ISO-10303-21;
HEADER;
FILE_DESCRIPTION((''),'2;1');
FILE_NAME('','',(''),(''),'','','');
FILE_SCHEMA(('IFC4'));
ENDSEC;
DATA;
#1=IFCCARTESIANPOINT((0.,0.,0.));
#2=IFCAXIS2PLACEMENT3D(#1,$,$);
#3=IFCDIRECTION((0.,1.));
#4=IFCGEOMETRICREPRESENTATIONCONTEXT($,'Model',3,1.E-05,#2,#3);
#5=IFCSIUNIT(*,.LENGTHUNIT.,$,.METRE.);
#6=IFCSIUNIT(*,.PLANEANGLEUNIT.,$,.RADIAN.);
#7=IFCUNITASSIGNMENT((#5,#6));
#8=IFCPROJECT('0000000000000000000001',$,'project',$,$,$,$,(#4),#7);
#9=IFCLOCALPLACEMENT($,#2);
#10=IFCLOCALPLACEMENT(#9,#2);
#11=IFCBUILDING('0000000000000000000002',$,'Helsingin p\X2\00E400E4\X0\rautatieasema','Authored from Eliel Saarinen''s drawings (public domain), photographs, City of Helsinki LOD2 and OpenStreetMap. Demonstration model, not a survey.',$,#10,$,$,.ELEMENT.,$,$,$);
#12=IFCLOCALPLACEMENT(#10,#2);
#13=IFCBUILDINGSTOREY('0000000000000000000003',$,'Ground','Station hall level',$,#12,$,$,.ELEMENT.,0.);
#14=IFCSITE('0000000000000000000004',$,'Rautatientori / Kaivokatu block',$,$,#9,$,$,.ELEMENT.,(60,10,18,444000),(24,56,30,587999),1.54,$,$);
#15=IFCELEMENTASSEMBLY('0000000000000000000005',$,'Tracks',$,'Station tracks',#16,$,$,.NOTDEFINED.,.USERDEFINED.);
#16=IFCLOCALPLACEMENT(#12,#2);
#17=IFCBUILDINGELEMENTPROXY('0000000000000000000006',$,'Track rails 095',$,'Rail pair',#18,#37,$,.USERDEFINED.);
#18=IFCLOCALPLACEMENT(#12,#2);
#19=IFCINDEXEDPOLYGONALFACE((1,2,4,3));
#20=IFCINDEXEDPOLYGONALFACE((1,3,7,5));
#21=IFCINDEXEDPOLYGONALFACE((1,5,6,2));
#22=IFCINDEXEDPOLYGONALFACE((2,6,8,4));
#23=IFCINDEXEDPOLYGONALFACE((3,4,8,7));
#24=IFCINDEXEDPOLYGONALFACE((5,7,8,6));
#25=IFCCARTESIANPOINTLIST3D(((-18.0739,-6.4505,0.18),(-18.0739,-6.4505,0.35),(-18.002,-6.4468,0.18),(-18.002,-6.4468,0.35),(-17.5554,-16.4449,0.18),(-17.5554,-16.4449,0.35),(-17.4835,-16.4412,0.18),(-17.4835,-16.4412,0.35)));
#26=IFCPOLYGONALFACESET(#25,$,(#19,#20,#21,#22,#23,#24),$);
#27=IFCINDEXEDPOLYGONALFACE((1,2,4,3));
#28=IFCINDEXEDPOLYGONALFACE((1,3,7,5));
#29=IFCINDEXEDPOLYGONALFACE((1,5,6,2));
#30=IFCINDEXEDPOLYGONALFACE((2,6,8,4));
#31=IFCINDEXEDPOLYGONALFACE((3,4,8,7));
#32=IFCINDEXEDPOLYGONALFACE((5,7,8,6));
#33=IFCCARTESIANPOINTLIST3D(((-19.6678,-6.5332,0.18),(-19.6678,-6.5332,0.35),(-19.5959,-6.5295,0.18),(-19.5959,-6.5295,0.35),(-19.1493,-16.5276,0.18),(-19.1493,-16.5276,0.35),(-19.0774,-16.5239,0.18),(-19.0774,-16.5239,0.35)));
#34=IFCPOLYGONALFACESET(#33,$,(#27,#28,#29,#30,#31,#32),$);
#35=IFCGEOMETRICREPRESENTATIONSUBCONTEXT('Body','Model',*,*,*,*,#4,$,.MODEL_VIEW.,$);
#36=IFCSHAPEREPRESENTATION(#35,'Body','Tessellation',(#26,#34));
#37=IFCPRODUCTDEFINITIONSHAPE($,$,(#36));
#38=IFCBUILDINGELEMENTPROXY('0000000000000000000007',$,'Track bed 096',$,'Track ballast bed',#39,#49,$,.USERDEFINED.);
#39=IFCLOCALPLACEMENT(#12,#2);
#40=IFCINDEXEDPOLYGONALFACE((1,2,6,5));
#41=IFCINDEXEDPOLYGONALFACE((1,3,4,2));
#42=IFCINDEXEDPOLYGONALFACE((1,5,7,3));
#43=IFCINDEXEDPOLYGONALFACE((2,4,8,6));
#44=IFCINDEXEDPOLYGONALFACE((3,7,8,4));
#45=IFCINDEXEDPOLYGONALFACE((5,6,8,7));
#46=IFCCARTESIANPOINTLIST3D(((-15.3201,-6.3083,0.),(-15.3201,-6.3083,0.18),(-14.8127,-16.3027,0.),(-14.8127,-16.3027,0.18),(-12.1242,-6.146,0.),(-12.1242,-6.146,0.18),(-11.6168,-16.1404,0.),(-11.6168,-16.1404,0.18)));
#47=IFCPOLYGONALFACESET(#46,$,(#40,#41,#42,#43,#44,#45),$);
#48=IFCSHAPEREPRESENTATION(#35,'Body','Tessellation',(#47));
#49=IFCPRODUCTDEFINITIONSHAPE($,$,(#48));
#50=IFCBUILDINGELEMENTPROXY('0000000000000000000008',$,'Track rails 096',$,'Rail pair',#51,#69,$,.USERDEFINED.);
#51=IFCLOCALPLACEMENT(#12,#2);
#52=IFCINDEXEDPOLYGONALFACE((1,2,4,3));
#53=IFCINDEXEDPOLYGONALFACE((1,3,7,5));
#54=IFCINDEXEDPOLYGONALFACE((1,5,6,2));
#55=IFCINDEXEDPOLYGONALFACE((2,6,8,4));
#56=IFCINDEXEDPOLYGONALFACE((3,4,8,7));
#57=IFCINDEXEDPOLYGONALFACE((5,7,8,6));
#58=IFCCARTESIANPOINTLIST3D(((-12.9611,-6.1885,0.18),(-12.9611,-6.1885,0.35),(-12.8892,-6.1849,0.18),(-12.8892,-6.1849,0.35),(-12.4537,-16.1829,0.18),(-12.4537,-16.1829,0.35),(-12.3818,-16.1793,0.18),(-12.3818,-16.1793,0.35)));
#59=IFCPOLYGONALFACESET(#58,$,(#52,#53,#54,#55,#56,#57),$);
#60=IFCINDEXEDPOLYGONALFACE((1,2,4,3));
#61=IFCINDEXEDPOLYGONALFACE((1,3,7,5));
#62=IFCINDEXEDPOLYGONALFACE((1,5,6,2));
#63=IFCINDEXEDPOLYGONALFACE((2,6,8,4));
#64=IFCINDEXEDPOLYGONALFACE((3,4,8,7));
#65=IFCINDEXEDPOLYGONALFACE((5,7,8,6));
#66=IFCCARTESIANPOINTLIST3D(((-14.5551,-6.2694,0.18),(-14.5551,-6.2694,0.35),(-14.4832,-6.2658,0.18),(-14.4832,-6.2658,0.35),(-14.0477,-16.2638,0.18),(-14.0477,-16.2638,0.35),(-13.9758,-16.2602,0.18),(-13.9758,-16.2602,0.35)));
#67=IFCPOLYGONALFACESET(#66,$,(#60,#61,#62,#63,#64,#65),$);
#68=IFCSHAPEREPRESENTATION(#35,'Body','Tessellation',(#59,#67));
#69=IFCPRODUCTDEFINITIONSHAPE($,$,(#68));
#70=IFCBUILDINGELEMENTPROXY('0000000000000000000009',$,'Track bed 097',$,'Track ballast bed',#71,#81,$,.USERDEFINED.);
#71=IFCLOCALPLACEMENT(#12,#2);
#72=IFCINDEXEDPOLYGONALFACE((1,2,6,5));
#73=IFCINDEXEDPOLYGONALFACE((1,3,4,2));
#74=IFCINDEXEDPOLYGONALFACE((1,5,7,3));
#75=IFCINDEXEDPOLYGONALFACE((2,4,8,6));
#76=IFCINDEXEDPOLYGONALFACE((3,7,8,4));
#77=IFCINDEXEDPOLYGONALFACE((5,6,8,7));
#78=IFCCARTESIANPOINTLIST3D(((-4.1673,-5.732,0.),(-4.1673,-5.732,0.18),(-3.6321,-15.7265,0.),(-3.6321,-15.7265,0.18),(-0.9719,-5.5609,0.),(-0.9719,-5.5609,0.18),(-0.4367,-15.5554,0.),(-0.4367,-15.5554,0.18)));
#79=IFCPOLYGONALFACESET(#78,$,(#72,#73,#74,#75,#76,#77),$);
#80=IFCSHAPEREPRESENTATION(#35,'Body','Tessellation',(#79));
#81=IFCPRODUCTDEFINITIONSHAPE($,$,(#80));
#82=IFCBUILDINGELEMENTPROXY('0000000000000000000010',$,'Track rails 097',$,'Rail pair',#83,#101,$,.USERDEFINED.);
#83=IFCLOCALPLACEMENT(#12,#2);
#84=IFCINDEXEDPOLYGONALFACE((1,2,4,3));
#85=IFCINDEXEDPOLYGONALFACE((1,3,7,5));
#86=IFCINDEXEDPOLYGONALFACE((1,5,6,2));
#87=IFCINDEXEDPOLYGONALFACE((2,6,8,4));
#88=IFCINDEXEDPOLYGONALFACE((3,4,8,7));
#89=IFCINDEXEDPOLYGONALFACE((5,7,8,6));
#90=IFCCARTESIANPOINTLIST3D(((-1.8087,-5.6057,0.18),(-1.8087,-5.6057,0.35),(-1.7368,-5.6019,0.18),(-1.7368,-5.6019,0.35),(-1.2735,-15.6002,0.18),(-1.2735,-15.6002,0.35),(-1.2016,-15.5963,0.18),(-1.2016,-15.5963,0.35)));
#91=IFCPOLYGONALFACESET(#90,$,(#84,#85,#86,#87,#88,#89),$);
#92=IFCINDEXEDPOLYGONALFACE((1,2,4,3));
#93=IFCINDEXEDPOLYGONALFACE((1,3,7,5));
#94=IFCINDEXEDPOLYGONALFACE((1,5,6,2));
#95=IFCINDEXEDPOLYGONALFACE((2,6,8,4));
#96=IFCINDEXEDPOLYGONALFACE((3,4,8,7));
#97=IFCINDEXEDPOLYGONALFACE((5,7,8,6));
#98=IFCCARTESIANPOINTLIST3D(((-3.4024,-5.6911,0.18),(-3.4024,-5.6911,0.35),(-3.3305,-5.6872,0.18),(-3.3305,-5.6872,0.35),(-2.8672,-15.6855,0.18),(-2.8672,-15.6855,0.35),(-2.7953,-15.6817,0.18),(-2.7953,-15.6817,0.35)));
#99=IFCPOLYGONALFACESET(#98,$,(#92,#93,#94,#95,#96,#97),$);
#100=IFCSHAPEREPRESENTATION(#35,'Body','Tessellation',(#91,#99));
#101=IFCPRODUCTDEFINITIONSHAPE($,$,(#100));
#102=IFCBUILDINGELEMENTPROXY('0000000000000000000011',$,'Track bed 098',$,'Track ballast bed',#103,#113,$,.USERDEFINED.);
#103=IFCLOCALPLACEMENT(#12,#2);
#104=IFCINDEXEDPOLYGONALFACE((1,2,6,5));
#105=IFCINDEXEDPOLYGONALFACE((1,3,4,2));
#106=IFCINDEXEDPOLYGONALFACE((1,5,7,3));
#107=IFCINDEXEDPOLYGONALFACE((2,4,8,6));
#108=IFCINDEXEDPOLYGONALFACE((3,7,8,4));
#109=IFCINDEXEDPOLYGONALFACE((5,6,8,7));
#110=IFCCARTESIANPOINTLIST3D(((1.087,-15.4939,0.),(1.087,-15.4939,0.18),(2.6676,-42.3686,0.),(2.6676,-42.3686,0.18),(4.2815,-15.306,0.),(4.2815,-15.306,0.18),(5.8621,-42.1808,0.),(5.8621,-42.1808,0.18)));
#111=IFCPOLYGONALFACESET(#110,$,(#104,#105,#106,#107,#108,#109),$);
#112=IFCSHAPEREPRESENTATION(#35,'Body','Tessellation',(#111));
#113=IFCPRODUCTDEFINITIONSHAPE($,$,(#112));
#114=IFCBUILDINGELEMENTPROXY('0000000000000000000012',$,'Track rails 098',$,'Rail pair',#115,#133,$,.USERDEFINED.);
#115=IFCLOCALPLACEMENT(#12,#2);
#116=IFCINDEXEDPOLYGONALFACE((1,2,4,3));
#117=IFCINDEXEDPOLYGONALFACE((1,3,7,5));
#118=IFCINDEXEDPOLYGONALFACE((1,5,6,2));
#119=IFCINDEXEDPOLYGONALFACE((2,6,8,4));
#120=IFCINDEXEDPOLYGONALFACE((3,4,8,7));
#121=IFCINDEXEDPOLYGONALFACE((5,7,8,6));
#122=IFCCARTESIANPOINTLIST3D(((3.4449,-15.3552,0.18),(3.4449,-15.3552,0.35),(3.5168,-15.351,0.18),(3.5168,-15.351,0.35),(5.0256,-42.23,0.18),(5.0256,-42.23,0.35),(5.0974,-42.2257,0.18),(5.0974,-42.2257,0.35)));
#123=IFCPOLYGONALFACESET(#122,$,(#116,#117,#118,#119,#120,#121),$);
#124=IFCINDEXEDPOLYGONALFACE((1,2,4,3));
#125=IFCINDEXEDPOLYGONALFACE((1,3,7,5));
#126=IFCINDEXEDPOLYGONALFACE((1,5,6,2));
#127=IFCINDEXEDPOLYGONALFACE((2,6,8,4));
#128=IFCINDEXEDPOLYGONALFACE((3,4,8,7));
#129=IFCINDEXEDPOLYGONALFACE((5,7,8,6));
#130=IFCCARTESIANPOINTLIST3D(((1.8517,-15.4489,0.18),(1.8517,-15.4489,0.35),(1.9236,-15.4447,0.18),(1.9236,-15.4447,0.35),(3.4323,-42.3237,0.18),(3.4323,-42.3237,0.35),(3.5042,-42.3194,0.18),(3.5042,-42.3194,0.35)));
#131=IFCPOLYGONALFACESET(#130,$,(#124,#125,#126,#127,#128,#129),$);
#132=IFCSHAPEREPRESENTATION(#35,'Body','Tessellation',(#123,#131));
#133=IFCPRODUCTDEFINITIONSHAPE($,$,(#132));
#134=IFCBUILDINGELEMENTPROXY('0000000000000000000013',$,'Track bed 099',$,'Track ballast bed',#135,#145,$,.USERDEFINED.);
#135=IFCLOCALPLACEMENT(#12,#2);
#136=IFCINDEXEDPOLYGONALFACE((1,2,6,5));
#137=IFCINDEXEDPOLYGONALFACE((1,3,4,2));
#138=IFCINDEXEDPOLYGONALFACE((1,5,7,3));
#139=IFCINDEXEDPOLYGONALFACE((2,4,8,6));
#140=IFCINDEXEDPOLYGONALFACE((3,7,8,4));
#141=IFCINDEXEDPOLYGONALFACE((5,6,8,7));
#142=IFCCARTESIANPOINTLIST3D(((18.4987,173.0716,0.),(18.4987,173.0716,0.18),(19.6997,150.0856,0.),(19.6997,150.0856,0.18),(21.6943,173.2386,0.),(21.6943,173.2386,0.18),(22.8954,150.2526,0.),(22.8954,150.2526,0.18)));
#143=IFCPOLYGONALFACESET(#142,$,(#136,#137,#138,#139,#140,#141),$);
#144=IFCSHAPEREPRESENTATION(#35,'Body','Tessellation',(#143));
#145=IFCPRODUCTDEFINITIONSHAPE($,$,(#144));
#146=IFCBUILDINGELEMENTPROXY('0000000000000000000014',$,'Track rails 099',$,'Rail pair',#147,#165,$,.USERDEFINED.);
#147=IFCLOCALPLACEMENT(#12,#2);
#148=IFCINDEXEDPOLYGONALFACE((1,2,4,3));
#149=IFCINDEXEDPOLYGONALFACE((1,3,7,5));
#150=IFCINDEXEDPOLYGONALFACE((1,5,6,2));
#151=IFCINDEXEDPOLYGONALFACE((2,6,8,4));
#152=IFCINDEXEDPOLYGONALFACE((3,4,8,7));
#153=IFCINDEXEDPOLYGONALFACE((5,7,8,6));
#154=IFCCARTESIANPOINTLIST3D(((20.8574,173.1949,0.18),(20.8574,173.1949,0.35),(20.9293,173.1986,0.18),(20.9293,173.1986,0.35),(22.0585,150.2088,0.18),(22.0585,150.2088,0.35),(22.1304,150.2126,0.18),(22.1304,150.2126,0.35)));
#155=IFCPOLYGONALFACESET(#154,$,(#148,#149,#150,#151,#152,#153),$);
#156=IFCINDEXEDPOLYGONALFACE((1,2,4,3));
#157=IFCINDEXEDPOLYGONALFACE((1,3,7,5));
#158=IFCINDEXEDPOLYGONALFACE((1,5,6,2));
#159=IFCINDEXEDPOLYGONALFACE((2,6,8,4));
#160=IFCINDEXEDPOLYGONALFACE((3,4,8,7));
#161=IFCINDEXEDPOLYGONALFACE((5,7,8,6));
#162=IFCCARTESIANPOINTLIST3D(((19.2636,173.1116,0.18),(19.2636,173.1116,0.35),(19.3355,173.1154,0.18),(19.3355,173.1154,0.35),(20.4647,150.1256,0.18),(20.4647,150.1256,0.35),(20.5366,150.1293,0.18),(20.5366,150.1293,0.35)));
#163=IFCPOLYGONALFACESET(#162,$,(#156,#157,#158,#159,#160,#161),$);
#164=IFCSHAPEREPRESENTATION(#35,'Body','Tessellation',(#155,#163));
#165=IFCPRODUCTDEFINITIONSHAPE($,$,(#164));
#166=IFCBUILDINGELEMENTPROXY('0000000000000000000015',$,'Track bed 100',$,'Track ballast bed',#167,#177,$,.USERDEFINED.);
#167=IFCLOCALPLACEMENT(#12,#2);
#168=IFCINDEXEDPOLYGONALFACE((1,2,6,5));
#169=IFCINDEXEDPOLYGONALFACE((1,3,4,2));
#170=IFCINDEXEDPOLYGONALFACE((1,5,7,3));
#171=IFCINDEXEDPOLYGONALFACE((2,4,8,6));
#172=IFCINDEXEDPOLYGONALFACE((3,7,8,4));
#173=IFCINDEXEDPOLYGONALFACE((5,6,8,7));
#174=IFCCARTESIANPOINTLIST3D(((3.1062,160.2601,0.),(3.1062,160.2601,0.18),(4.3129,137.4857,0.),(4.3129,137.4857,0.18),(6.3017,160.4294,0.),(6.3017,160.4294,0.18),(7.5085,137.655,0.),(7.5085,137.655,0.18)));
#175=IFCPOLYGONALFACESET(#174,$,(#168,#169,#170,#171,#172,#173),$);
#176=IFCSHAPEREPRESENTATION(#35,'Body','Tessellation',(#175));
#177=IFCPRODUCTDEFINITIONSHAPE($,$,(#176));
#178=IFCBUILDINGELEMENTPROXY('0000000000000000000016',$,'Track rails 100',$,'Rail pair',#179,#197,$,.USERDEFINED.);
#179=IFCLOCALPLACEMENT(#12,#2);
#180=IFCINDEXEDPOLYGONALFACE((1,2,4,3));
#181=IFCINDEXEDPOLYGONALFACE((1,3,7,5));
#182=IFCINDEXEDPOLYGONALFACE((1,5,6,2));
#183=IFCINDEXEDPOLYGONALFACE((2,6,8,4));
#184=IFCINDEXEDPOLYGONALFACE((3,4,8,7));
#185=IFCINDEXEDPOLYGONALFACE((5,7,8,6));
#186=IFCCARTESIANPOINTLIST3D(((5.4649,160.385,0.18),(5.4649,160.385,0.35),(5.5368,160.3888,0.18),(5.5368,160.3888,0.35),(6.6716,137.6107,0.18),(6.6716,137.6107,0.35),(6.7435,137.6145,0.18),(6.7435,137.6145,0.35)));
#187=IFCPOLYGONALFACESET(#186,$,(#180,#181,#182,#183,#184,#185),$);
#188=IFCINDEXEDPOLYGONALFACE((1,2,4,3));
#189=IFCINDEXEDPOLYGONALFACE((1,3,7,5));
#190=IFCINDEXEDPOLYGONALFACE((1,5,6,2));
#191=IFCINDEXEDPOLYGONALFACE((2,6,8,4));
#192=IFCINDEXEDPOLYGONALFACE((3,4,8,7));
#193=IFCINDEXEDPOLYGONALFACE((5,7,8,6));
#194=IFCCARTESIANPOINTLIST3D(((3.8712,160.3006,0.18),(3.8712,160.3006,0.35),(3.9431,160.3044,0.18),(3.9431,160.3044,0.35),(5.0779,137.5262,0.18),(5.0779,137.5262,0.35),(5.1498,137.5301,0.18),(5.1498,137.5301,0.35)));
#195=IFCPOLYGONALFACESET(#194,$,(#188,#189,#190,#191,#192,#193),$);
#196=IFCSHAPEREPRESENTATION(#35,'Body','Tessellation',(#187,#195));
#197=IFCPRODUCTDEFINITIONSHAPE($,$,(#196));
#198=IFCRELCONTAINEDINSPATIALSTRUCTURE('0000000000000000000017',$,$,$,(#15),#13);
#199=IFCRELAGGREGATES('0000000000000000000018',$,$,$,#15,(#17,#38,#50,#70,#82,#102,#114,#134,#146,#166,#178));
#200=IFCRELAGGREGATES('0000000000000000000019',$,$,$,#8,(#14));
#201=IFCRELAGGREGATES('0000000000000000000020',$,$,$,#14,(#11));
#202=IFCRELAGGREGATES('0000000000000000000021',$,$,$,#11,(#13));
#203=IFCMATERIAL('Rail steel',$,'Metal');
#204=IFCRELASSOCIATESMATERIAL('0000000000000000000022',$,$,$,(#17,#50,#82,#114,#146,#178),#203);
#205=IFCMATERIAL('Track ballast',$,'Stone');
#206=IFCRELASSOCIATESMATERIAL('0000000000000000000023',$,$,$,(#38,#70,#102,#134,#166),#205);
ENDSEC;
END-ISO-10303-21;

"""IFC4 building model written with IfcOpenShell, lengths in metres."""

from ifc_helpers import new_model, si_unit, direction, frame, origin, place, context, subcontext, project, spatial, polyline, outline, extrude, material, element, aggregate, save


model = new_model("IFC4")

# Units and contexts
model_context = context("Model", 3, precision=1e-05, world=origin(), true_north=direction((0.0, 1.0)))
body_context = subcontext(model_context, "Body", "Model", "MODEL_VIEW")
ifc_project = project(units=[si_unit("LENGTHUNIT", "METRE"), si_unit("PLANEANGLEUNIT", "RADIAN")], contexts=[model_context])

# Site, building, storey
site_placement = place(None, origin())
site = spatial("IfcSite", under=ifc_project, at=site_placement, Name="Rautatientori / Kaivokatu block", CompositionType="ELEMENT", RefLatitude=(60, 10, 18, 444000), RefLongitude=(24, 56, 30, 587999), RefElevation=1.54)
building_placement = place(site_placement, origin())
building = spatial("IfcBuilding", under=site, at=building_placement, Name="Helsingin päärautatieasema", Description="Authored from Eliel Saarinen's drawings (public domain), photographs, City of Helsinki LOD2 and OpenStreetMap. Demonstration model, not a survey.", CompositionType="ELEMENT")
storey_placement = place(building_placement, origin())
storey = spatial("IfcBuildingStorey", under=building, at=storey_placement, Name="Ground", Description="Station hall level", CompositionType="ELEMENT", Elevation=0.0)

# Element assembly, building element proxies
assembly_placement = place(building_placement, origin())
assembly = element("IfcElementAssembly", 1, at=assembly_placement, inside=storey, Name="Tracks", ObjectType="Station tracks", AssemblyPlace="NOTDEFINED", PredefinedType="USERDEFINED")
ifc_material_1 = material(Name="Track ballast", Category="Stone")
ifc_material_2 = material(Name="Rail steel", Category="Metal")
proxy_1_placement = place(building_placement, origin())
proxy_1 = element("IfcBuildingElementProxy", 2, at=proxy_1_placement, material=ifc_material_2, Name="Track rails 095", ObjectType="Rail pair", PredefinedType="USERDEFINED", context=body_context, shape_type="SweptSolid", body=[
    extrude(outline(polyline([(-18.0739, -6.4505), (-18.002, -6.4468), (-17.4835, -16.4412), (-17.5554, -16.4449), (-18.0739, -6.4505)])), frame((0.0, 0.0, 0.18)), (0.0, 0.0, 1.0), 0.17),
    extrude(outline(polyline([(-19.6678, -6.5332), (-19.5959, -6.5295), (-19.0774, -16.5239), (-19.1493, -16.5276), (-19.6678, -6.5332)])), frame((0.0, 0.0, 0.18)), (0.0, 0.0, 1.0), 0.17),
])
proxy_2_placement = place(building_placement, origin())
proxy_2 = element("IfcBuildingElementProxy", 3, at=proxy_2_placement, material=ifc_material_1, Name="Track bed 096", ObjectType="Track ballast bed", PredefinedType="USERDEFINED", context=body_context, shape_type="SweptSolid", body=[
    extrude(outline(polyline([(-15.3201, -6.3083), (-12.1242, -6.146), (-11.6168, -16.1404), (-14.8127, -16.3027), (-15.3201, -6.3083)])), origin(), (0.0, 0.0, 1.0), 0.18),
])
proxy_3_placement = place(building_placement, origin())
proxy_3 = element("IfcBuildingElementProxy", 4, at=proxy_3_placement, material=ifc_material_2, Name="Track rails 096", ObjectType="Rail pair", PredefinedType="USERDEFINED", context=body_context, shape_type="SweptSolid", body=[
    extrude(outline(polyline([(-12.9611, -6.1885), (-12.8892, -6.1849), (-12.3818, -16.1793), (-12.4537, -16.1829), (-12.9611, -6.1885)])), frame((0.0, 0.0, 0.18)), (0.0, 0.0, 1.0), 0.17),
    extrude(outline(polyline([(-14.5551, -6.2694), (-14.4832, -6.2658), (-13.9758, -16.2602), (-14.0477, -16.2638), (-14.5551, -6.2694)])), frame((0.0, 0.0, 0.18)), (0.0, 0.0, 1.0), 0.17),
])
proxy_4_placement = place(building_placement, origin())
proxy_4 = element("IfcBuildingElementProxy", 5, at=proxy_4_placement, material=ifc_material_1, Name="Track bed 097", ObjectType="Track ballast bed", PredefinedType="USERDEFINED", context=body_context, shape_type="SweptSolid", body=[
    extrude(outline(polyline([(-4.1673, -5.732), (-0.9719, -5.5609), (-0.4367, -15.5554), (-3.6321, -15.7265), (-4.1673, -5.732)])), origin(), (0.0, 0.0, 1.0), 0.18),
])
proxy_5_placement = place(building_placement, origin())
proxy_5 = element("IfcBuildingElementProxy", 6, at=proxy_5_placement, material=ifc_material_2, Name="Track rails 097", ObjectType="Rail pair", PredefinedType="USERDEFINED", context=body_context, shape_type="SweptSolid", body=[
    extrude(outline(polyline([(-1.8087, -5.6057), (-1.7368, -5.6019), (-1.2016, -15.5963), (-1.2735, -15.6002), (-1.8087, -5.6057)])), frame((0.0, 0.0, 0.18)), (0.0, 0.0, 1.0), 0.17),
    extrude(outline(polyline([(-3.4024, -5.6911), (-3.3305, -5.6872), (-2.7953, -15.6817), (-2.8672, -15.6855), (-3.4024, -5.6911)])), frame((0.0, 0.0, 0.18)), (0.0, 0.0, 1.0), 0.17),
])
proxy_6_placement = place(building_placement, origin())
proxy_6 = element("IfcBuildingElementProxy", 7, at=proxy_6_placement, material=ifc_material_1, Name="Track bed 098", ObjectType="Track ballast bed", PredefinedType="USERDEFINED", context=body_context, shape_type="SweptSolid", body=[
    extrude(outline(polyline([(1.087, -15.4939), (4.2815, -15.306), (5.8621, -42.1808), (2.6676, -42.3686), (1.087, -15.4939)])), origin(), (0.0, 0.0, 1.0), 0.18),
])
proxy_7_placement = place(building_placement, origin())
proxy_7 = element("IfcBuildingElementProxy", 8, at=proxy_7_placement, material=ifc_material_2, Name="Track rails 098", ObjectType="Rail pair", PredefinedType="USERDEFINED", context=body_context, shape_type="SweptSolid", body=[
    extrude(outline(polyline([(3.4449, -15.3552), (3.5168, -15.351), (5.0974, -42.2257), (5.0256, -42.23), (3.4449, -15.3552)])), frame((0.0, 0.0, 0.18)), (0.0, 0.0, 1.0), 0.17),
    extrude(outline(polyline([(1.8517, -15.4489), (1.9236, -15.4447), (3.5042, -42.3194), (3.4323, -42.3237), (1.8517, -15.4489)])), frame((0.0, 0.0, 0.18)), (0.0, 0.0, 1.0), 0.17),
])
proxy_8_placement = place(building_placement, origin())
proxy_8 = element("IfcBuildingElementProxy", 9, at=proxy_8_placement, material=ifc_material_1, Name="Track bed 099", ObjectType="Track ballast bed", PredefinedType="USERDEFINED", context=body_context, shape_type="SweptSolid", body=[
    extrude(outline(polyline([(18.4987, 173.0716), (21.6943, 173.2386), (22.8954, 150.2526), (19.6997, 150.0856), (18.4987, 173.0716)])), origin(), (0.0, 0.0, 1.0), 0.18),
])
proxy_9_placement = place(building_placement, origin())
proxy_9 = element("IfcBuildingElementProxy", 10, at=proxy_9_placement, material=ifc_material_2, Name="Track rails 099", ObjectType="Rail pair", PredefinedType="USERDEFINED", context=body_context, shape_type="SweptSolid", body=[
    extrude(outline(polyline([(20.8574, 173.1949), (20.9293, 173.1986), (22.1304, 150.2126), (22.0585, 150.2088), (20.8574, 173.1949)])), frame((0.0, 0.0, 0.18)), (0.0, 0.0, 1.0), 0.17),
    extrude(outline(polyline([(19.2636, 173.1116), (19.3355, 173.1154), (20.5366, 150.1293), (20.4647, 150.1256), (19.2636, 173.1116)])), frame((0.0, 0.0, 0.18)), (0.0, 0.0, 1.0), 0.17),
])
proxy_10_placement = place(building_placement, origin())
proxy_10 = element("IfcBuildingElementProxy", 11, at=proxy_10_placement, material=ifc_material_1, Name="Track bed 100", ObjectType="Track ballast bed", PredefinedType="USERDEFINED", context=body_context, shape_type="SweptSolid", body=[
    extrude(outline(polyline([(3.1062, 160.2601), (6.3017, 160.4294), (7.5085, 137.655), (4.3129, 137.4857), (3.1062, 160.2601)])), origin(), (0.0, 0.0, 1.0), 0.18),
])
proxy_11_placement = place(building_placement, origin())
proxy_11 = element("IfcBuildingElementProxy", 12, at=proxy_11_placement, material=ifc_material_2, Name="Track rails 100", ObjectType="Rail pair", PredefinedType="USERDEFINED", context=body_context, shape_type="SweptSolid", body=[
    extrude(outline(polyline([(5.4649, 160.385), (5.5368, 160.3888), (6.7435, 137.6145), (6.6716, 137.6107), (5.4649, 160.385)])), frame((0.0, 0.0, 0.18)), (0.0, 0.0, 1.0), 0.17),
    extrude(outline(polyline([(3.8712, 160.3006), (3.9431, 160.3044), (5.1498, 137.5301), (5.0779, 137.5262), (3.8712, 160.3006)])), frame((0.0, 0.0, 0.18)), (0.0, 0.0, 1.0), 0.17),
])
aggregate(assembly, [proxy_1, proxy_2, proxy_3, proxy_4, proxy_5, proxy_6, proxy_7, proxy_8, proxy_9, proxy_10, proxy_11])

save(model, "model.ifc")
